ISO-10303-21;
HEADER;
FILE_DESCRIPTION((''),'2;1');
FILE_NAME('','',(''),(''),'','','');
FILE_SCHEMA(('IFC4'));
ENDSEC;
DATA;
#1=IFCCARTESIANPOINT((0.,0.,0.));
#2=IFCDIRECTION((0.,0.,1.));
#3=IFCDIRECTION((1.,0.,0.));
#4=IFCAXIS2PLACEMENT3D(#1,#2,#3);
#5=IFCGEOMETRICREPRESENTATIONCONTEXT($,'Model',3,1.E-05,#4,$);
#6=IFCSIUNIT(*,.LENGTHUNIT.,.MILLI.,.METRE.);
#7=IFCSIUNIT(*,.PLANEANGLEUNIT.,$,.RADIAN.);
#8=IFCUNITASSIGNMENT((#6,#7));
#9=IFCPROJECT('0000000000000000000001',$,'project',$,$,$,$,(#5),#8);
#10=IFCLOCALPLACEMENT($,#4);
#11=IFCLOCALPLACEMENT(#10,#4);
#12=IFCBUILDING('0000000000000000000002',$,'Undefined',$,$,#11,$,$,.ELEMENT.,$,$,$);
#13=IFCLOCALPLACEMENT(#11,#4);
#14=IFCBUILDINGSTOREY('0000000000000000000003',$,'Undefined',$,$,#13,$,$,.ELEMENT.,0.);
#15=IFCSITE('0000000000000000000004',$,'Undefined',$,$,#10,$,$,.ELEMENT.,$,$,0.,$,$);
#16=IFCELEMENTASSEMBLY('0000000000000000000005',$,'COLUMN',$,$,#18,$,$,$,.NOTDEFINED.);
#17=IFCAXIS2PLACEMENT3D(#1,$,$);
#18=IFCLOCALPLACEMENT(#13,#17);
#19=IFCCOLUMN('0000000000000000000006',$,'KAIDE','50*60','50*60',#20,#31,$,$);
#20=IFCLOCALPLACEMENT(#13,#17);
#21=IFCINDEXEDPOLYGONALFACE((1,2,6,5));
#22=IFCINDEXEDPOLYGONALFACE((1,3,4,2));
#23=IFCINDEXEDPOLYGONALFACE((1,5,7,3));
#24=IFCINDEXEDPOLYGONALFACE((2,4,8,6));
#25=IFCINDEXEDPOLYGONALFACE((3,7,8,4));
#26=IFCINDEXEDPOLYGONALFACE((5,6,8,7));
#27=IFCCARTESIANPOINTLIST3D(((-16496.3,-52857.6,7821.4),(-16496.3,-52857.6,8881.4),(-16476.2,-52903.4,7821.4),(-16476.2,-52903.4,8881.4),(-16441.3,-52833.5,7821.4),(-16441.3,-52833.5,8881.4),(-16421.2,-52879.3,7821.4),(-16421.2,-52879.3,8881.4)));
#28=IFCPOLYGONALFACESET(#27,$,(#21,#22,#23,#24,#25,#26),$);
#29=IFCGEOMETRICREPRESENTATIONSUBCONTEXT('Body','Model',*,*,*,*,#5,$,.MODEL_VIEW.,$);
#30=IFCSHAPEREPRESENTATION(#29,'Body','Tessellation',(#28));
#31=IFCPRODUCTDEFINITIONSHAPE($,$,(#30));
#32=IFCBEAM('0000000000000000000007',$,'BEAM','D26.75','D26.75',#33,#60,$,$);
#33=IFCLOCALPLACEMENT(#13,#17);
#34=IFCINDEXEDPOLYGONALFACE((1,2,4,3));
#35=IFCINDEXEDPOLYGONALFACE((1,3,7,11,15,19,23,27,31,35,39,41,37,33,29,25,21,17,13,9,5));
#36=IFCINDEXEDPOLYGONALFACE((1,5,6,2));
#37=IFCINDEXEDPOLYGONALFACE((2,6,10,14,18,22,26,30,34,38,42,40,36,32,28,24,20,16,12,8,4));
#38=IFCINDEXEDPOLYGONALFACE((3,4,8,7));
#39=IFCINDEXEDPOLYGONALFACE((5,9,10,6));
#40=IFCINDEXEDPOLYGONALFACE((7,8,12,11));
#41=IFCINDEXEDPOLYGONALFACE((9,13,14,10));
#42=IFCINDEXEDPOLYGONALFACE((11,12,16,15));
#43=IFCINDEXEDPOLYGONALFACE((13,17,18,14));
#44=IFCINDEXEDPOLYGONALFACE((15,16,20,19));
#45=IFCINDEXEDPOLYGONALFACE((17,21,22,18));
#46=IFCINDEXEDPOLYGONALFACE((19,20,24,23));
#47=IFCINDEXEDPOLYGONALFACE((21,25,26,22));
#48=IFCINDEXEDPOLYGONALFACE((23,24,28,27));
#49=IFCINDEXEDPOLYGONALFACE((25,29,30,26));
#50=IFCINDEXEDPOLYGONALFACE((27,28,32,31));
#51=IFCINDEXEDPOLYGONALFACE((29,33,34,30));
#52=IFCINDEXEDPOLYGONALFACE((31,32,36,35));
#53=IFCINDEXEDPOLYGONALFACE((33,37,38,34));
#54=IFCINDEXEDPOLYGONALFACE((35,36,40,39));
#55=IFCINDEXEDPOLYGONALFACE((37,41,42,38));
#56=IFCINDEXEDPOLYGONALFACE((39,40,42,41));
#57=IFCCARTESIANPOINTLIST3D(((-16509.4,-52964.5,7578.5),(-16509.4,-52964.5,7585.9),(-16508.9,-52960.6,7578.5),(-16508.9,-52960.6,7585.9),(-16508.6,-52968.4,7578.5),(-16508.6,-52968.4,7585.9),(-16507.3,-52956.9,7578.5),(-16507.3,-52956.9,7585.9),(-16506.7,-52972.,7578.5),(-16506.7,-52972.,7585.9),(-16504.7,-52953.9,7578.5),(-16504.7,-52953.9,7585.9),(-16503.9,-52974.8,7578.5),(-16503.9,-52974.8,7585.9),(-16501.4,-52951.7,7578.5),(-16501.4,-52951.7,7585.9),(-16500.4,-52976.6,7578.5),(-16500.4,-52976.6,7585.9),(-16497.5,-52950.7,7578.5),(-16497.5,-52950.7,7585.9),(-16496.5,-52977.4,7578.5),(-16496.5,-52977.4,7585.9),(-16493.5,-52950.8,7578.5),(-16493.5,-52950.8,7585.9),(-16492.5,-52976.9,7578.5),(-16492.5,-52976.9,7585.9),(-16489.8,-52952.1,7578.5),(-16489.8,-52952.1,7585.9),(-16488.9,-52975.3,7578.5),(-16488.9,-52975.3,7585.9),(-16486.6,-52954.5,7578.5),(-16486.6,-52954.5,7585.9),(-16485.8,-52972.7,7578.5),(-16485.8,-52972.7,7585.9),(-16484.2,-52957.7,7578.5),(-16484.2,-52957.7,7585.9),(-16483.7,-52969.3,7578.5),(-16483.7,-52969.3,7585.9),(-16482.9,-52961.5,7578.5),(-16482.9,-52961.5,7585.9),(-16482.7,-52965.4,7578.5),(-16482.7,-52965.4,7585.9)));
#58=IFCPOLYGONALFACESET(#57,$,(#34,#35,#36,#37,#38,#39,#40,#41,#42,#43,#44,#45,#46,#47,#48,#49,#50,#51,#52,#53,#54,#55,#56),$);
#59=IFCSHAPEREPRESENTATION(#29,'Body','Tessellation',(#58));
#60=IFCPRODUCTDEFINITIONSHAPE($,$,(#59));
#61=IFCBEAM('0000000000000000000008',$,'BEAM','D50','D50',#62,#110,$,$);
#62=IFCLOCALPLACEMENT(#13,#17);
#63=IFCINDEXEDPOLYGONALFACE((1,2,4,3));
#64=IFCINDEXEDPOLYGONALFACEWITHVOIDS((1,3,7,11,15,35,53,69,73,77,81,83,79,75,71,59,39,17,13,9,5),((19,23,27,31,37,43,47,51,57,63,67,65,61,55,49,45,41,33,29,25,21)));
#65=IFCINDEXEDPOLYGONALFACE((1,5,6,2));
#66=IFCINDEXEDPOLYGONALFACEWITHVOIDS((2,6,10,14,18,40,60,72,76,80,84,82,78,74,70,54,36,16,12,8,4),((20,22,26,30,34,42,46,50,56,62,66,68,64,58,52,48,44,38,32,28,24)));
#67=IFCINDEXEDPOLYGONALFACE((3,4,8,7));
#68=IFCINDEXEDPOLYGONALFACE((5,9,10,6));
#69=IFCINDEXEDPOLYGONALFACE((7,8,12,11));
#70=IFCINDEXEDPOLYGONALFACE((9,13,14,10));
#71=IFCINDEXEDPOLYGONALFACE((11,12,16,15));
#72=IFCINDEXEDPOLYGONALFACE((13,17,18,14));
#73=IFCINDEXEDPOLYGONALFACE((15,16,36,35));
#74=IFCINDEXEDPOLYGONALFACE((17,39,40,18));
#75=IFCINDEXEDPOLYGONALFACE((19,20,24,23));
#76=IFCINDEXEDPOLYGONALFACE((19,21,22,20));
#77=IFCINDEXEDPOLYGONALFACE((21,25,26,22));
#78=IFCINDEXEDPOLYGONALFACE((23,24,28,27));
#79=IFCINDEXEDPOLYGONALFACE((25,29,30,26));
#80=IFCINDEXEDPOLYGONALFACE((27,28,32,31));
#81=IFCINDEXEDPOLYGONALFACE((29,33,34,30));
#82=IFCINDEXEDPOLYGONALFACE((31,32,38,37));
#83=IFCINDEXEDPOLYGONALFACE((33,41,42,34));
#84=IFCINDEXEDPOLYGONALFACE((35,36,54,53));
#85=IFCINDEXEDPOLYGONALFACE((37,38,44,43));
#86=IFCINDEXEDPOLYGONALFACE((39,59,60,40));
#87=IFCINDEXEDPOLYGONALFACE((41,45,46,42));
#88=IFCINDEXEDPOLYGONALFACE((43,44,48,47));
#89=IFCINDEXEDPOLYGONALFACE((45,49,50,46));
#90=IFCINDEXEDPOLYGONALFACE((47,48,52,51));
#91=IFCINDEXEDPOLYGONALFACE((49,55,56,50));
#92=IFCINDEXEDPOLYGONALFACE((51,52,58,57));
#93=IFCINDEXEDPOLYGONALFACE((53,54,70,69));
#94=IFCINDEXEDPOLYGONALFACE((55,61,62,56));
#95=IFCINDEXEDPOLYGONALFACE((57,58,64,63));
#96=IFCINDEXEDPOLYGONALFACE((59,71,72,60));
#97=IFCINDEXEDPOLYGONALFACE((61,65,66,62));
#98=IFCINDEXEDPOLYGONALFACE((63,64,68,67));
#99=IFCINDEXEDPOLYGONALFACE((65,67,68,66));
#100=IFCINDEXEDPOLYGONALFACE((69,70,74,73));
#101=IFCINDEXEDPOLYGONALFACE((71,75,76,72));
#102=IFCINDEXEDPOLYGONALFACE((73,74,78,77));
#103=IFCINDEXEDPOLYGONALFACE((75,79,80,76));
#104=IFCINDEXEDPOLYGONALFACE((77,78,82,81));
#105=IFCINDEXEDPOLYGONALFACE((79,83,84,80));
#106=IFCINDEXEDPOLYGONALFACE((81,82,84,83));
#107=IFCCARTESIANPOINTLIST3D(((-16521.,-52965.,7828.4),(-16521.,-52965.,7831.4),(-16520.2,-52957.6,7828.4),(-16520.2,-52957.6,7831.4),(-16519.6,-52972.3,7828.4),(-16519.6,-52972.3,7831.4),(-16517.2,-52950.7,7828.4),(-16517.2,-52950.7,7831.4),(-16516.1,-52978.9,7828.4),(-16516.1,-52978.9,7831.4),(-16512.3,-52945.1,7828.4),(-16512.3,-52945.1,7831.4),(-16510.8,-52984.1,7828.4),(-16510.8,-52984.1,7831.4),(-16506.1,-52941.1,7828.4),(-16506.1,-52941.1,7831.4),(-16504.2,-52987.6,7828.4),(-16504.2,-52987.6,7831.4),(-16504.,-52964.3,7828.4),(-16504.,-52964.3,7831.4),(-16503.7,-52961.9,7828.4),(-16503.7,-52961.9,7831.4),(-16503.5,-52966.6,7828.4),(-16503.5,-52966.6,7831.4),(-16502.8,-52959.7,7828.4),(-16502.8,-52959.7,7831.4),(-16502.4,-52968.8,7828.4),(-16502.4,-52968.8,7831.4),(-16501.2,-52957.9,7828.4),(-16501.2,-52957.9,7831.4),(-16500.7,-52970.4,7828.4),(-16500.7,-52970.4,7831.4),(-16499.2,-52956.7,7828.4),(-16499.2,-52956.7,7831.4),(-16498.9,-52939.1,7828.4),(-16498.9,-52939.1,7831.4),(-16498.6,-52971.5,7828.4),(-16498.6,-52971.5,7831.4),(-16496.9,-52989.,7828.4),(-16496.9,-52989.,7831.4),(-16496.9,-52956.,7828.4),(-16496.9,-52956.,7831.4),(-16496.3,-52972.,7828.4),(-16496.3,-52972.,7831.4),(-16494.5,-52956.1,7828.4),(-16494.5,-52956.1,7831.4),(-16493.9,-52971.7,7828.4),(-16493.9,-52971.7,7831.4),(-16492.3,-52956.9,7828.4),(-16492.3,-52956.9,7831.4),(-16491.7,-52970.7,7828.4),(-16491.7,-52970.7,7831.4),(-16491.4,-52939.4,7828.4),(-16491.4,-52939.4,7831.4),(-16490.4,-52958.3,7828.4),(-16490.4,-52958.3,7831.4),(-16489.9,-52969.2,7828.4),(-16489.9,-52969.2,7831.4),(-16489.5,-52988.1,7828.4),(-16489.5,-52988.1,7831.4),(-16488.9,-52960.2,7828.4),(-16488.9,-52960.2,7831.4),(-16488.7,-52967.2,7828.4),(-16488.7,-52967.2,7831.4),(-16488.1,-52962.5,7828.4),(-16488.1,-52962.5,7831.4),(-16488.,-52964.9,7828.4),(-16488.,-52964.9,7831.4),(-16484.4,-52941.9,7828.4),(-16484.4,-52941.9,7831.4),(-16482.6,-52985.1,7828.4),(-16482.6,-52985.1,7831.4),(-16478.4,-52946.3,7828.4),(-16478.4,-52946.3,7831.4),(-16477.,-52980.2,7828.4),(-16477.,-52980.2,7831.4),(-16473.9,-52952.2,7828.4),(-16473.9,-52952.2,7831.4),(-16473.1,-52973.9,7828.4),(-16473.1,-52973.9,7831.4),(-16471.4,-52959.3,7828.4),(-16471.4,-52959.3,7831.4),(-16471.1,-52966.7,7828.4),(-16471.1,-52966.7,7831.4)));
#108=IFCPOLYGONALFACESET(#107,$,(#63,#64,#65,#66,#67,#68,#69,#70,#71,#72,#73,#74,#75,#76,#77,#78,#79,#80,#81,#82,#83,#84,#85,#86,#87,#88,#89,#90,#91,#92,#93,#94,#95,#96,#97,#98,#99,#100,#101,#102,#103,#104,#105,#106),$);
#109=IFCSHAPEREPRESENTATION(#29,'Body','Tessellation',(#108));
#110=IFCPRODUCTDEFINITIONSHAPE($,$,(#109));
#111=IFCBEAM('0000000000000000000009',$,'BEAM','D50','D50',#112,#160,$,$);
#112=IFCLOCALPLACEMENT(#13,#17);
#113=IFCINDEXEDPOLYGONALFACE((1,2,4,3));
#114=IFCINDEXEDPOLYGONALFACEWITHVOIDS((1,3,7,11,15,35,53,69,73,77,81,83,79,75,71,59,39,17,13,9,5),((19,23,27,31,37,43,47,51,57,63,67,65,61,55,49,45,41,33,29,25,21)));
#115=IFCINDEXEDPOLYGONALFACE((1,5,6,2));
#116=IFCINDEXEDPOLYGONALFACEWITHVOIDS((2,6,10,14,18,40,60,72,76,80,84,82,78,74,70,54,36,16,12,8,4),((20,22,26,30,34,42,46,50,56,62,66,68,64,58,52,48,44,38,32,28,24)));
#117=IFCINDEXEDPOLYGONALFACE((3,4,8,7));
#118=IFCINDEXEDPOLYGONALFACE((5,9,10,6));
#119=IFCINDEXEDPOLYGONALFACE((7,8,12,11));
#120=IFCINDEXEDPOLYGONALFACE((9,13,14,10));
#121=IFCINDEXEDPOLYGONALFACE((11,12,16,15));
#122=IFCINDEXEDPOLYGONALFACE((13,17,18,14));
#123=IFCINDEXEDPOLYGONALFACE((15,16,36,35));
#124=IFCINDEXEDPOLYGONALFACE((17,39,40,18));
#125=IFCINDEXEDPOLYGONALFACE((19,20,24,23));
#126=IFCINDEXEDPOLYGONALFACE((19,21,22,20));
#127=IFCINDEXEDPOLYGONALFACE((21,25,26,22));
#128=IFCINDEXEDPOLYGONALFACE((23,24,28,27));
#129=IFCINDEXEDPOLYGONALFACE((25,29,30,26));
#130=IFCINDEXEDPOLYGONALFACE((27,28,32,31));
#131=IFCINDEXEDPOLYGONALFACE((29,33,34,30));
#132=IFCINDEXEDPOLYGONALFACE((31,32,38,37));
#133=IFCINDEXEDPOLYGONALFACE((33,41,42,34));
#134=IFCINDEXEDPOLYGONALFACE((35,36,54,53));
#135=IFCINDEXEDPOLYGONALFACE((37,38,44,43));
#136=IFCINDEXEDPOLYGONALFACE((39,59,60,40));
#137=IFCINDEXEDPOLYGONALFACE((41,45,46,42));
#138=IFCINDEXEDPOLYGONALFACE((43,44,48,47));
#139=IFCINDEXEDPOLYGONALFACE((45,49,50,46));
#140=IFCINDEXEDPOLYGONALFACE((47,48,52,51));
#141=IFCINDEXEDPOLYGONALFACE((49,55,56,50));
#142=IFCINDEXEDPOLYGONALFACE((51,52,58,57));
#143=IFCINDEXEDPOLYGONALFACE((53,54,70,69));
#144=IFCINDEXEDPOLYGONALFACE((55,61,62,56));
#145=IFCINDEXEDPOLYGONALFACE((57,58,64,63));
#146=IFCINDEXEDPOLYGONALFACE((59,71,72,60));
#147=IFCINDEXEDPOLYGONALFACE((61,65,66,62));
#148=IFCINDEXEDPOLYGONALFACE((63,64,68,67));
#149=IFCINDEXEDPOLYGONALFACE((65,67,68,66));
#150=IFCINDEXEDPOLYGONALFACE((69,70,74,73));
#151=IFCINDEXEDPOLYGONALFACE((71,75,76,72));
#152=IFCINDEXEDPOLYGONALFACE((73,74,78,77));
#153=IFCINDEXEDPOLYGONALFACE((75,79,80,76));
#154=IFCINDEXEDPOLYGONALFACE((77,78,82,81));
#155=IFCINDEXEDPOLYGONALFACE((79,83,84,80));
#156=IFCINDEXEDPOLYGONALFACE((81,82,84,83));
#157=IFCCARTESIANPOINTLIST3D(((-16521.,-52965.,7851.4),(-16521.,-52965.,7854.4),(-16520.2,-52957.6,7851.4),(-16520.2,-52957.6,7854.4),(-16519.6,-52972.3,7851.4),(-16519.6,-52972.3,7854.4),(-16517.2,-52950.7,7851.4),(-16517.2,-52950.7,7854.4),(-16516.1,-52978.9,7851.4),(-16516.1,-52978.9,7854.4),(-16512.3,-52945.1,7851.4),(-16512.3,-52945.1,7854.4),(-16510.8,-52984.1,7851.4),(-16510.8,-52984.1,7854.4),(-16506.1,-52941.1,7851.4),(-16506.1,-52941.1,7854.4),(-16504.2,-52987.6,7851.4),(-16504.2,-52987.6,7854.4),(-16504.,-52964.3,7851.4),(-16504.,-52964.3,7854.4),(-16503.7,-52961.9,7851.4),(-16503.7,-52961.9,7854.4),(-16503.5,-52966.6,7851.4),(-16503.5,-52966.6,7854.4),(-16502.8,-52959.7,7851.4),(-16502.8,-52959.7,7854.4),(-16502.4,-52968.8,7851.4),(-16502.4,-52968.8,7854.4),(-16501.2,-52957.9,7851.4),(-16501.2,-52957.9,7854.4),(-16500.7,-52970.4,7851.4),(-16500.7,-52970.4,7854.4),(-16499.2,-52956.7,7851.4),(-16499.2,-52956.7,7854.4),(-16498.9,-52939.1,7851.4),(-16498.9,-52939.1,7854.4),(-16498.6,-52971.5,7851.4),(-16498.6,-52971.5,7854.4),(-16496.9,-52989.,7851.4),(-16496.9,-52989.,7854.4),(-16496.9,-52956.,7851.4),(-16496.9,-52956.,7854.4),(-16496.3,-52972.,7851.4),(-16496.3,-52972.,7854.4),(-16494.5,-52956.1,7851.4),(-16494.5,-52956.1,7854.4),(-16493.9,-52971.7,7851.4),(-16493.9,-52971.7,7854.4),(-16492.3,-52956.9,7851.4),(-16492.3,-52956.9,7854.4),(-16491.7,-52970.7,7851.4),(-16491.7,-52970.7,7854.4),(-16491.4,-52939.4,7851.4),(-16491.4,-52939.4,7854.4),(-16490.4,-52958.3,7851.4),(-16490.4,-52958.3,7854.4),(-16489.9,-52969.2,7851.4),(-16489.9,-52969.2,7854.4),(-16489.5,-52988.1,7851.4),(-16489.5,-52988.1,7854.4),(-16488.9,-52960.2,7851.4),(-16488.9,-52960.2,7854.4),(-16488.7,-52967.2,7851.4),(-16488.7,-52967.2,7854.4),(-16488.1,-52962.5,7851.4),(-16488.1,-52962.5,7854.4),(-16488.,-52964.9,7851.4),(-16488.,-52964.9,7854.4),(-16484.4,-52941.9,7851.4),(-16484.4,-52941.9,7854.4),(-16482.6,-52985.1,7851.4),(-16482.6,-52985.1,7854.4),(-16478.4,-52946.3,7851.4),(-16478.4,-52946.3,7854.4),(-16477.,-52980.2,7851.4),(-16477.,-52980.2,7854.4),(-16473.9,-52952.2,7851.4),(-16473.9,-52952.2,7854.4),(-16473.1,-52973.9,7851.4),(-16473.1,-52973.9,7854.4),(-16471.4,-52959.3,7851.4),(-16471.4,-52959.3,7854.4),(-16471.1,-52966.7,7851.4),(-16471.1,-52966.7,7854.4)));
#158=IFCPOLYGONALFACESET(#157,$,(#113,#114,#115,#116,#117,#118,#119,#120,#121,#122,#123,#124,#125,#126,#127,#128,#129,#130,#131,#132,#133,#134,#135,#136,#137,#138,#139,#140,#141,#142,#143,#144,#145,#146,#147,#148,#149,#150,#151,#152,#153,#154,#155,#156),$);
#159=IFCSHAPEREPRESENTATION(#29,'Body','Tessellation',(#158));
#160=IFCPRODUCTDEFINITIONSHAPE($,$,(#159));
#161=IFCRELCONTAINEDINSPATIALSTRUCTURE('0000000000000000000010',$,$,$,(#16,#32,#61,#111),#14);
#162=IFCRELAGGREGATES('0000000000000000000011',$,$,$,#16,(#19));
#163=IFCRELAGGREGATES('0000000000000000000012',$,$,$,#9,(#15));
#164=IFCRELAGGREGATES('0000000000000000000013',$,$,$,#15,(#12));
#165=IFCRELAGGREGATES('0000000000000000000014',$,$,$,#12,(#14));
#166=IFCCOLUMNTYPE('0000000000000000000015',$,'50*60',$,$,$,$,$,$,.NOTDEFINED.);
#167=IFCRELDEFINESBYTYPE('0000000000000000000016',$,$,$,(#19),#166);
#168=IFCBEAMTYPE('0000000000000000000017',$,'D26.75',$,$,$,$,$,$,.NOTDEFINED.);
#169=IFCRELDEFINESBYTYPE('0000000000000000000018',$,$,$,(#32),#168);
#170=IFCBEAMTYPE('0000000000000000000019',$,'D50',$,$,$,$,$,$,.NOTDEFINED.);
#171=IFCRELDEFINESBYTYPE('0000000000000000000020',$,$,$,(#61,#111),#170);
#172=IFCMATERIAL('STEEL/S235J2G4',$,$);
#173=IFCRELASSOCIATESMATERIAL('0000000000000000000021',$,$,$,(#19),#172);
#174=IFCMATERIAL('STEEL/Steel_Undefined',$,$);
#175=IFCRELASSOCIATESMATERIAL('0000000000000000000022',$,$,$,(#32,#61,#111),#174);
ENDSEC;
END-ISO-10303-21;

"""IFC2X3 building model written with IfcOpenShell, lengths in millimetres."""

from ifc_helpers import new_model, si_unit, frame, origin_with_axes, origin_2d_with_axis, place, context, subcontext, project, spatial, rectangle, circle, extrude, material, type_object, element, aggregate, save


model = new_model("IFC2X3")

# Units and contexts
model_context = context("Model", 3, precision=1e-05, world=origin_with_axes())
body_context = subcontext(model_context, "Body", "Model", "MODEL_VIEW")
ifc_project = project(units=[si_unit("LENGTHUNIT", "METRE", prefix="MILLI"), si_unit("PLANEANGLEUNIT", "RADIAN")], contexts=[model_context])

# Site, building, storey
site_placement = place(None, origin_with_axes())
site = spatial("IfcSite", under=ifc_project, at=site_placement, Name="Undefined", CompositionType="ELEMENT", RefElevation=0.0)
building_placement = place(site_placement, origin_with_axes())
building = spatial("IfcBuilding", under=site, at=building_placement, Name="Undefined", CompositionType="ELEMENT")
storey_placement = place(building_placement, origin_with_axes())
storey = spatial("IfcBuildingStorey", under=building, at=storey_placement, Name="Undefined", CompositionType="ELEMENT", Elevation=0.0)

# Element assembly, column
assembly_placement = place(storey_placement, frame((-16458.7, -52868.4, 7821.4), z_axis=(-0.402198, 0.915553, 0.0), x_axis=(0.0, 0.0, 1.0)))
assembly = element("IfcElementAssembly", 1, at=assembly_placement, inside=storey, Name="COLUMN", PredefinedType="NOTDEFINED")
ifc_material_1 = material(Name="STEEL/S235J2G4")
column_type = type_object("IfcColumnType", Name="50*60", PredefinedType="NOTDEFINED")
column_placement = place(storey_placement, frame((-16458.7, -52868.4, 7821.4), z_axis=(0.0, 0.0, 1.0), x_axis=(1.0, 0.0, 0.0)))
column = element("IfcColumn", 2, at=column_placement, type_object=column_type, material=ifc_material_1, Name="KAIDE", Description="50*60", ObjectType="50*60", context=body_context, shape_type="SweptSolid", body=[
    extrude(rectangle(XDim=60.0, YDim=50.0, at=origin_2d_with_axis()), frame((0.0, 0.0, 1060.0), z_axis=(0.0, 0.0, -1.0), x_axis=(-0.915553, -0.402197, 0.0)), (0.0, 0.0, 1.0), 1060.0),
])
aggregate(assembly, [column])

# Shared definitions
ifc_material_2 = material(Name="STEEL/Steel_Undefined")
beam_type_1 = type_object("IfcBeamType", Name="D26.75", PredefinedType="NOTDEFINED")

# Beam
beam_1_placement = place(storey_placement, frame((-16496.0, -52964.0, 7585.9), z_axis=(-0.915553, -0.402197, 0.0), x_axis=(0.0, 0.0, -1.0)))
element("IfcBeam", 3, at=beam_1_placement, inside=storey, type_object=beam_type_1, material=ifc_material_2, Name="BEAM", Description="D26.75", ObjectType="D26.75", context=body_context, shape_type="SweptSolid", body=[
    extrude(circle(Radius=13.4, at=origin_2d_with_axis()), frame((7.4, 0.0, 0.0), z_axis=(-1.0, 0.0, 0.0), x_axis=(0.0, -1.0, 0.0)), (0.0, 0.0, 1.0), 7.4),
])

# Beams, openings
beam_type_2 = type_object("IfcBeamType", Name="D50", PredefinedType="NOTDEFINED")
beam_2_placement = place(storey_placement, frame((-16496.0, -52964.0, 7831.4), z_axis=(-0.915553, -0.402197, 0.0), x_axis=(0.0, 0.0, -1.0)))
beam_2 = element("IfcBeam", 4, at=beam_2_placement, inside=storey, type_object=beam_type_2, material=ifc_material_2, Name="BEAM", Description="D50", ObjectType="D50", context=body_context, shape_type="SweptSolid", body=[
    extrude(circle(Radius=25.0, at=origin_2d_with_axis()), frame((3.0, 0.0, 0.0), z_axis=(-1.0, 0.0, 0.0), x_axis=(0.0, -1.0, 0.0)), (0.0, 0.0, 1.0), 3.0),
])
opening_1_placement = place(storey_placement, frame((-16496.0, -52964.0, 7831.4), z_axis=(-0.915553, -0.402197, 0.0), x_axis=(0.0, 0.0, -1.0)))
element("IfcOpeningElement", 5, at=opening_1_placement, cuts=beam_2, ObjectType="Recess", context=body_context, shape_type="SweptSolid", body=[
    extrude(circle(Radius=8.0, at=origin_2d_with_axis()), frame((245.5, 0.0, 0.0), z_axis=(-1.0, 0.0, 0.0), x_axis=(0.0, -1.0, 0.0)), (0.0, 0.0, 1.0), 292.6),
])
beam_3_placement = place(storey_placement, frame((-16496.0, -52964.0, 7854.4), z_axis=(-0.915553, -0.402197, 0.0), x_axis=(0.0, 0.0, -1.0)))
beam_3 = element("IfcBeam", 6, at=beam_3_placement, inside=storey, type_object=beam_type_2, material=ifc_material_2, Name="BEAM", Description="D50", ObjectType="D50", context=body_context, shape_type="SweptSolid", body=[
    extrude(circle(Radius=25.0, at=origin_2d_with_axis()), frame((3.0, 0.0, 0.0), z_axis=(-1.0, 0.0, 0.0), x_axis=(0.0, -1.0, 0.0)), (0.0, 0.0, 1.0), 3.0),
])
opening_2_placement = place(storey_placement, frame((-16496.0, -52964.0, 7854.4), z_axis=(-0.915553, -0.402197, 0.0), x_axis=(0.0, 0.0, -1.0)))
element("IfcOpeningElement", 7, at=opening_2_placement, cuts=beam_3, ObjectType="Recess", context=body_context, shape_type="SweptSolid", body=[
    extrude(circle(Radius=8.0, at=origin_2d_with_axis()), frame((268.5, 0.0, 0.0), z_axis=(-1.0, 0.0, 0.0), x_axis=(0.0, -1.0, 0.0)), (0.0, 0.0, 1.0), 292.6),
])

save(model, "model.ifc")
